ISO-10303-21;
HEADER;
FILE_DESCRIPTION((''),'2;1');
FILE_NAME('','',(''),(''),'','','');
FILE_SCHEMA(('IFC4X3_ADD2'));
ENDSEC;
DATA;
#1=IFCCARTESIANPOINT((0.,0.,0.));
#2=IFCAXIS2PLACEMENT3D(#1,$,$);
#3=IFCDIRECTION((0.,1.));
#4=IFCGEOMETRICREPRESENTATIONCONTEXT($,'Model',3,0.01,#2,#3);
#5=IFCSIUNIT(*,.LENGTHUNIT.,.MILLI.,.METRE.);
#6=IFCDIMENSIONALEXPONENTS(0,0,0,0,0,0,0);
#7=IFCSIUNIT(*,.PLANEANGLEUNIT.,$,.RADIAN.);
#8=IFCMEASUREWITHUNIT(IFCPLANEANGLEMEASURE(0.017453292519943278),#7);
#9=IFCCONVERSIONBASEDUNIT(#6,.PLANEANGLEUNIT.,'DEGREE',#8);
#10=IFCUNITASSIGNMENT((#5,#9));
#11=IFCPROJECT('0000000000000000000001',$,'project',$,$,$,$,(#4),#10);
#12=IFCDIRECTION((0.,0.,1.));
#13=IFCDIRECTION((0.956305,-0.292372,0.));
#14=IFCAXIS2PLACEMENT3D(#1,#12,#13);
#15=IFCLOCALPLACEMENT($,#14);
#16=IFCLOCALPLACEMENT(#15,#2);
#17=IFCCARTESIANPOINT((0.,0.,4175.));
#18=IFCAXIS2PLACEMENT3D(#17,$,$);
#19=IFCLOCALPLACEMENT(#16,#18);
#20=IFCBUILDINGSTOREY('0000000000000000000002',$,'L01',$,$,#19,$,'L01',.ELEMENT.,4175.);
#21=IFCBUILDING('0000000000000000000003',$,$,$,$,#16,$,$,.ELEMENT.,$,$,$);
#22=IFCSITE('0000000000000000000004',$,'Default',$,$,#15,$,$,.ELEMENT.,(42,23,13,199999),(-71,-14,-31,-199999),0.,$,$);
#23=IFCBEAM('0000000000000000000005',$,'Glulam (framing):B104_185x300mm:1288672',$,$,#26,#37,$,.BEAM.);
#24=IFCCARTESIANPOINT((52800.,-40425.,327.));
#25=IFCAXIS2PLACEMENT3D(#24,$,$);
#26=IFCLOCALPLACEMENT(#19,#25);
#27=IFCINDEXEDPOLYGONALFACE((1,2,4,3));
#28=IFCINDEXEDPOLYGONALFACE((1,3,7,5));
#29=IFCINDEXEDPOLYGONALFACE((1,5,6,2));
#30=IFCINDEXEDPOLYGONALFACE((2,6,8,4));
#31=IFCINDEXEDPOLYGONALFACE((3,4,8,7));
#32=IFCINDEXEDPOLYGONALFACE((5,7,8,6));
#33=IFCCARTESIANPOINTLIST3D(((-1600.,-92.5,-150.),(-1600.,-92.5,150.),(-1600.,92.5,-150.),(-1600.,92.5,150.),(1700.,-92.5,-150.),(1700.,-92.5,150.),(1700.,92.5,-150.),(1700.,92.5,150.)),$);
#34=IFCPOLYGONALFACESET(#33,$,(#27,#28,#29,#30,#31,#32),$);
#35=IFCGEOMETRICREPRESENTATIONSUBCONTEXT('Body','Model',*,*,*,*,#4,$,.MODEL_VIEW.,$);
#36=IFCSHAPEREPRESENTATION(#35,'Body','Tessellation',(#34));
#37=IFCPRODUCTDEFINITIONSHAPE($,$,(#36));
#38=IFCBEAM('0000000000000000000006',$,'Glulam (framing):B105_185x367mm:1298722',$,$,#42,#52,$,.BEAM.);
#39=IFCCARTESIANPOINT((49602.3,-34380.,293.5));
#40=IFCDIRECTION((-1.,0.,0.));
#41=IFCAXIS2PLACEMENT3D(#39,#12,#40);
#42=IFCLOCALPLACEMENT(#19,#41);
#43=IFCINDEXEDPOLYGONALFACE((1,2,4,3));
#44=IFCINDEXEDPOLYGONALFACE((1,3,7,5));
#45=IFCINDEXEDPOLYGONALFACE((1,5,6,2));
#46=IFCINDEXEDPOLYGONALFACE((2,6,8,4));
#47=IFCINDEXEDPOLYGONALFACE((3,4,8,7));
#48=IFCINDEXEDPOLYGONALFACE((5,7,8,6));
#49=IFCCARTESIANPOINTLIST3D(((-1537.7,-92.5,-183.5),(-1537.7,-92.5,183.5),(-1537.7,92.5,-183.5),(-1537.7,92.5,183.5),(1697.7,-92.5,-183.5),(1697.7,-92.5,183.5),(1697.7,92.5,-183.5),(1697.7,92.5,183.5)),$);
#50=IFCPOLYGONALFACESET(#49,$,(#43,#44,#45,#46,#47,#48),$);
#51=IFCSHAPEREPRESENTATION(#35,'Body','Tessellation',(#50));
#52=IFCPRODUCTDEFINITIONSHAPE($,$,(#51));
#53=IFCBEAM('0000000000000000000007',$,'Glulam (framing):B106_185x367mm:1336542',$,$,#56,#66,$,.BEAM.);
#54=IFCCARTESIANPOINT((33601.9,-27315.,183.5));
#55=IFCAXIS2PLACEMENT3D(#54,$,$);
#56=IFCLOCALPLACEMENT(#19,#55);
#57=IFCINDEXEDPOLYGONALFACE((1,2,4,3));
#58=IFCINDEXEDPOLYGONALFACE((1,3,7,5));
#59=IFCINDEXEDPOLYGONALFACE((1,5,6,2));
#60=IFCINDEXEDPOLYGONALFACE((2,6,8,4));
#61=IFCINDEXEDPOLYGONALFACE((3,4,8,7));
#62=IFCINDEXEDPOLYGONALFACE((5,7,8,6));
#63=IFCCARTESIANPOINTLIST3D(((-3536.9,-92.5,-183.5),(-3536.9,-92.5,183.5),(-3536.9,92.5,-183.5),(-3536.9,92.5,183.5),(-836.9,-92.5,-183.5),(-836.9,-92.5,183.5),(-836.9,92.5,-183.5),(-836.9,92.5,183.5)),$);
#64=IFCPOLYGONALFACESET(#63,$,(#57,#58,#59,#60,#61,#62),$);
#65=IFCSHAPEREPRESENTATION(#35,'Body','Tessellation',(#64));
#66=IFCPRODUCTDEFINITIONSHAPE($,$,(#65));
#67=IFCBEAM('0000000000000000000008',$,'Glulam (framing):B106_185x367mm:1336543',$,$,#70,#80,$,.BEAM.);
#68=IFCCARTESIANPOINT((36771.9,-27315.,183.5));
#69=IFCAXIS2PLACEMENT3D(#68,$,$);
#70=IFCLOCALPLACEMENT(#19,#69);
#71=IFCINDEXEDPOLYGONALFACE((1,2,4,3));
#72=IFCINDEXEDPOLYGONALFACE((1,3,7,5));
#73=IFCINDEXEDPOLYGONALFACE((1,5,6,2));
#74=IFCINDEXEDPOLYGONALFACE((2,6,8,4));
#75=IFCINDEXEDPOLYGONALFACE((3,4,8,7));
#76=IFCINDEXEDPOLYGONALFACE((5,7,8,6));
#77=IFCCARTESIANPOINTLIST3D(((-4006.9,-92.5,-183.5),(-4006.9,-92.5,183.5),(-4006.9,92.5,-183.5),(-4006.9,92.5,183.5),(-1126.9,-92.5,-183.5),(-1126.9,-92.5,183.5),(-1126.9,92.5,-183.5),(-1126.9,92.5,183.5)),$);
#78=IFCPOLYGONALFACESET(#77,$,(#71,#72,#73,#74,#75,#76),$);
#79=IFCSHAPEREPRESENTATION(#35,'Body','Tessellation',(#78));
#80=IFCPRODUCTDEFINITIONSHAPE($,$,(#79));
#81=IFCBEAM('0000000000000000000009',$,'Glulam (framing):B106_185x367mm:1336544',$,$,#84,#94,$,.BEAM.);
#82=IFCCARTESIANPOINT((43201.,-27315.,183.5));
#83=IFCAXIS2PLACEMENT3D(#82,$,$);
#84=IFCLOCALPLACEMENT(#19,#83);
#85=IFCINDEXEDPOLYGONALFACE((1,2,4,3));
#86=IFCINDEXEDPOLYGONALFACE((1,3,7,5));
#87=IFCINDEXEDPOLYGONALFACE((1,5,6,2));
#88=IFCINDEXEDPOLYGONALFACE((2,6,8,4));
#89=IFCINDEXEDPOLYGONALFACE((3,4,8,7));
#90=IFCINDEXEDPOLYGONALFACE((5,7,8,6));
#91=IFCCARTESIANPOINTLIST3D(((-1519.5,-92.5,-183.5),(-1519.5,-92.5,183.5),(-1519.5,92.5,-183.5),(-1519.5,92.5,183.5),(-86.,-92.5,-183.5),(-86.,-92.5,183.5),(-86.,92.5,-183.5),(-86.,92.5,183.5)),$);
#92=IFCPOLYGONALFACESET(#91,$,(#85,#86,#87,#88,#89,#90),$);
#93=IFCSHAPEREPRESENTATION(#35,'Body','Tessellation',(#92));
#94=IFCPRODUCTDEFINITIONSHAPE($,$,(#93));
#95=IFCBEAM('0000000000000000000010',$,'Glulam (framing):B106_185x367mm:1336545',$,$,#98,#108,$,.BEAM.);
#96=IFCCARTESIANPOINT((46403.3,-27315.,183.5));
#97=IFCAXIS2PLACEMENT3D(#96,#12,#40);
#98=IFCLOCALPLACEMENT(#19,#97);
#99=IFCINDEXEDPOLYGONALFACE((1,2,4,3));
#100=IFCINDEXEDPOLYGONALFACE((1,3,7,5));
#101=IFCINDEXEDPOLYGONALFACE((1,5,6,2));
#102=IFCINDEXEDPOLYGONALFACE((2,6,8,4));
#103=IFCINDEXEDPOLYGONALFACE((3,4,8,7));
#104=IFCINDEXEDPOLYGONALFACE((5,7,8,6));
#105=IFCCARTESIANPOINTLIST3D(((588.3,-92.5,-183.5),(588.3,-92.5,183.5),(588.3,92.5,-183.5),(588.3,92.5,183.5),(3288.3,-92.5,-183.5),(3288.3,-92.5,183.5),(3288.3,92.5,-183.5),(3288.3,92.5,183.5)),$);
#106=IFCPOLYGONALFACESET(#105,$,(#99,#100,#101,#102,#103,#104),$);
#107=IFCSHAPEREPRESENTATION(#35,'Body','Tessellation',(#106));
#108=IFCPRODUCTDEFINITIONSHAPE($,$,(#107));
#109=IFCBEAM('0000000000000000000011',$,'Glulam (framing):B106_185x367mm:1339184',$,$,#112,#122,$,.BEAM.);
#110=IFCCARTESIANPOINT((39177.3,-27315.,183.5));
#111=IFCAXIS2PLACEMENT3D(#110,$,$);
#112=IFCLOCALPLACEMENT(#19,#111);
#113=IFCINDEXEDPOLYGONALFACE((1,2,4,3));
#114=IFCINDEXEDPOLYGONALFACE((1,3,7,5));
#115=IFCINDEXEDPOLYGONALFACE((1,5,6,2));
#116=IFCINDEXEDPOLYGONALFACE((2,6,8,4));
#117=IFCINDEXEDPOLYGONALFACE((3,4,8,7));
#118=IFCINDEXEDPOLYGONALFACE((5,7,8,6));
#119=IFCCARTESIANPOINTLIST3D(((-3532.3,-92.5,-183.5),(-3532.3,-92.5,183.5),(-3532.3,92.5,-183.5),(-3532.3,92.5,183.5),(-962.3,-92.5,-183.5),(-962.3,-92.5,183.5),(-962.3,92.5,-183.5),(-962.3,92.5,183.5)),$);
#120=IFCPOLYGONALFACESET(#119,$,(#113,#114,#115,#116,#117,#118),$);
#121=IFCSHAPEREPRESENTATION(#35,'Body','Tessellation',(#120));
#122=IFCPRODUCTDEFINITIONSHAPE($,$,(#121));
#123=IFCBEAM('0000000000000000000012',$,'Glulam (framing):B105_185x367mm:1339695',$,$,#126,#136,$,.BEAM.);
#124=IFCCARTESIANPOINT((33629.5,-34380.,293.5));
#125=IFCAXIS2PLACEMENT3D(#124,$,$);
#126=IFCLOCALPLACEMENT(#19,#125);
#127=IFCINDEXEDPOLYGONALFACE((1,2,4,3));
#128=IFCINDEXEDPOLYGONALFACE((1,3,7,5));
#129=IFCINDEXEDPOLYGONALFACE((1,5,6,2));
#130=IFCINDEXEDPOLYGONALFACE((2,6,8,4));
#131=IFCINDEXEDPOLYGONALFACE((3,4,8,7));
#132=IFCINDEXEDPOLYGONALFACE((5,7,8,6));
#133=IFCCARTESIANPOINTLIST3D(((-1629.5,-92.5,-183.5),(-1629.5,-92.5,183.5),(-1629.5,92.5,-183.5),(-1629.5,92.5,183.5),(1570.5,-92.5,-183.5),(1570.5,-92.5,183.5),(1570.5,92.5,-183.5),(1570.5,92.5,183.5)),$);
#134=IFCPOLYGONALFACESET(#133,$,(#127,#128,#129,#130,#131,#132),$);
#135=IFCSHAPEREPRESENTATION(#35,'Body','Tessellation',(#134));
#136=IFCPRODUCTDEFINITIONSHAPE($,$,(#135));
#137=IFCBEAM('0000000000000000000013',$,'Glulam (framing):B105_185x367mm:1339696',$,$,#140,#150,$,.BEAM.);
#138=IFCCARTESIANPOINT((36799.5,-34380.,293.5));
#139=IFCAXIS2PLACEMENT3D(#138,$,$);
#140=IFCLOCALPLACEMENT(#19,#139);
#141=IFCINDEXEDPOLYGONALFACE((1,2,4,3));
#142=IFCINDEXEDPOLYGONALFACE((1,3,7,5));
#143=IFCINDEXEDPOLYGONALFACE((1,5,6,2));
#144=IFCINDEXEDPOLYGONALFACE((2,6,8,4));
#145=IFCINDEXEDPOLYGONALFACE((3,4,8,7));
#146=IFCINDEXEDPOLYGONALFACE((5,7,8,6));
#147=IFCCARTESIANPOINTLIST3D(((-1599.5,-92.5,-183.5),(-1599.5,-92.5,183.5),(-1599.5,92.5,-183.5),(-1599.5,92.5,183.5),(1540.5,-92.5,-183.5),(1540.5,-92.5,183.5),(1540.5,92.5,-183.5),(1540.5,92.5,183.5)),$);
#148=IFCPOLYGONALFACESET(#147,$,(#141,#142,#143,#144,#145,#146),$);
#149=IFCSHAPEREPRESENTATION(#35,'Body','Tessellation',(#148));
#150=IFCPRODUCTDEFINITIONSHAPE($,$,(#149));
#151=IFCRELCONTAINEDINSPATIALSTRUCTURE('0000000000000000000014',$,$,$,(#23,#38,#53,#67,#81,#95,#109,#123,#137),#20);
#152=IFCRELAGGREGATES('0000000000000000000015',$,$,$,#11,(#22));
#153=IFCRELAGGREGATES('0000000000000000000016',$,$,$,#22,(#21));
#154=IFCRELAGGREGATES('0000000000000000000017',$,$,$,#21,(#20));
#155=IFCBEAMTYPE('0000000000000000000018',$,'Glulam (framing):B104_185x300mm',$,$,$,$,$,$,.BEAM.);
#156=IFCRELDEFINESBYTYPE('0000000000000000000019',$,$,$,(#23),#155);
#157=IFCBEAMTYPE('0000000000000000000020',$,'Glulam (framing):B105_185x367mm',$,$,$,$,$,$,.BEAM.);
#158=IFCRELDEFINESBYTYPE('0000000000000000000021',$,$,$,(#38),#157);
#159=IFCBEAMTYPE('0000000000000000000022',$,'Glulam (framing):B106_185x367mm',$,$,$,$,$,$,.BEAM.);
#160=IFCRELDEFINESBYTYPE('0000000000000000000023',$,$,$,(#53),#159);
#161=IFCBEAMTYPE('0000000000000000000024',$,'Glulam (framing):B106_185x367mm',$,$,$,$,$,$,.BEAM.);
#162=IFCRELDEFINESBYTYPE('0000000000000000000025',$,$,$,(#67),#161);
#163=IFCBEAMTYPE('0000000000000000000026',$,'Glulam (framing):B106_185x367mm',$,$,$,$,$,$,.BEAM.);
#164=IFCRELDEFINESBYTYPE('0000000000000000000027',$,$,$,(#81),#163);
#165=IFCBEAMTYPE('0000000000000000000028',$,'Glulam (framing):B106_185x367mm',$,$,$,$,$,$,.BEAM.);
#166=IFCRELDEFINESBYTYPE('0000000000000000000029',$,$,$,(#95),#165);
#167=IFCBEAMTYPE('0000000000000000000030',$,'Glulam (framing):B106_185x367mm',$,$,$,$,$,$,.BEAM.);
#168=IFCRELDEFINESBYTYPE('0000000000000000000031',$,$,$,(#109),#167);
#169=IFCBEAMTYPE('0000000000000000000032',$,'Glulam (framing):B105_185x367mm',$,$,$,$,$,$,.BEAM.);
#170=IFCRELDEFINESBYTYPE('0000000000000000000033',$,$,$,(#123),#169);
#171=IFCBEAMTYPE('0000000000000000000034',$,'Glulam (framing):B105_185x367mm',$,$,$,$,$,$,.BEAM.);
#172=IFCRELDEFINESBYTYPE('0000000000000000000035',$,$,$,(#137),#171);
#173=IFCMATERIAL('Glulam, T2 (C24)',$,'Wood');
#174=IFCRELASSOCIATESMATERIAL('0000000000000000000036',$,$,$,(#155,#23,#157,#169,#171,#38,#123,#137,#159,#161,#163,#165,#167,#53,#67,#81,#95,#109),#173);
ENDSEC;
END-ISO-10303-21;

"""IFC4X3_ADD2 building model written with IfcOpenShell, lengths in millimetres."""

from ifc_helpers import new_model, entity, si_unit, converted_unit, direction, frame, frame_2d, origin, origin_2d_with_axis, place, context, subcontext, project, spatial, rectangle, extrude, source, transform, mapped, material, material_profile, profile_set, profile_usage, type_object, type_shapes, element, save


model = new_model("IFC4X3_ADD2")

# Units and contexts
model_context = context("Model", 3, precision=0.01, world=origin(), true_north=direction((0.0, 1.0)))
body_context = subcontext(model_context, "Body", "Model", "MODEL_VIEW")
ifc_project = project(units=[si_unit("LENGTHUNIT", "METRE", prefix="MILLI"), converted_unit("PLANEANGLEUNIT", "DEGREE", entity("IfcPlaneAngleMeasure", 0.017453292519943278), si_unit("PLANEANGLEUNIT", "RADIAN"), dimensions=[0, 0, 0, 0, 0, 0, 0])], contexts=[model_context])

# Site, building, storey
site_placement = place(None, frame((0.0, 0.0, 0.0), z_axis=(0.0, 0.0, 1.0), x_axis=(0.956305, -0.292372, 0.0)))
site = spatial("IfcSite", under=ifc_project, at=site_placement, Name="Default", CompositionType="ELEMENT", RefLatitude=(42, 23, 13, 199999), RefLongitude=(-71, -14, -31, -199999), RefElevation=0.0)
building_placement = place(site_placement, origin())
building = spatial("IfcBuilding", under=site, at=building_placement, CompositionType="ELEMENT")
storey_placement = place(building_placement, frame((0.0, 0.0, 4175.0)))
storey = spatial("IfcBuildingStorey", under=building, at=storey_placement, Name="L01", LongName="L01", CompositionType="ELEMENT", Elevation=4175.0)

# Beams
ifc_material_1 = material(Name="Glulam, T2 (C24)", Category="Wood")
ifc_material_profile_1 = material_profile(ifc_material_1, rectangle(XDim=3380.0, YDim=185.0, at=origin_2d_with_axis()), Name="B104_185x300mm")
ifc_profile_set_1 = profile_set([ifc_material_profile_1], Name="B104_185x300mm")
ifc_profile_usage_1 = profile_usage(ifc_profile_set_1, cardinal=8)
beam_type_1 = type_object("IfcBeamType", Name="Glulam (framing):B104_185x300mm", PredefinedType="BEAM", material=ifc_profile_set_1)
shared_shape_1 = source(origin(), body_context, "Body", "SweptSolid", [
    extrude(rectangle(XDim=3300.0, YDim=185.0, at=origin_2d_with_axis()), frame((50.0, 0.0, -150.0), z_axis=(0.0, 0.0, 1.0), x_axis=(-1.0, 0.0, 0.0)), (0.0, 0.0, 1.0), 300.0),
])
type_shapes(beam_type_1, [shared_shape_1])
beam_1_placement = place(storey_placement, frame((52800.0, -40425.0, 327.0)))
element("IfcBeam", 1, at=beam_1_placement, inside=storey, type_object=beam_type_1, material=ifc_profile_usage_1, Name="Glulam (framing):B104_185x300mm:1288672", PredefinedType="BEAM", context=body_context, shape_type="MappedRepresentation", body=[
    mapped(shared_shape_1, transform((0.0, 0.0, 0.0), scale=1.0)),
])
ifc_material_profile_2 = material_profile(ifc_material_1, rectangle(XDim=3241.9, YDim=185.0, at=origin_2d_with_axis()), Name="B105_185x367mm")
ifc_profile_set_2 = profile_set([ifc_material_profile_2], Name="B105_185x367mm")
ifc_profile_usage_2 = profile_usage(ifc_profile_set_2, cardinal=8)
beam_type_2 = type_object("IfcBeamType", Name="Glulam (framing):B105_185x367mm", PredefinedType="BEAM", material=ifc_profile_set_2)
shared_shape_2 = source(origin(), body_context, "Body", "SweptSolid", [
    extrude(rectangle(XDim=3235.4, YDim=185.0, at=origin_2d_with_axis()), frame((80.0, 0.0, -183.5), z_axis=(0.0, 0.0, 1.0), x_axis=(-1.0, 0.0, 0.0)), (0.0, 0.0, 1.0), 367.0),
])
type_shapes(beam_type_2, [shared_shape_2])
beam_2_placement = place(storey_placement, frame((49602.3, -34380.0, 293.5), z_axis=(0.0, 0.0, 1.0), x_axis=(-1.0, 0.0, 0.0)))
element("IfcBeam", 2, at=beam_2_placement, inside=storey, type_object=beam_type_2, material=ifc_profile_usage_2, Name="Glulam (framing):B105_185x367mm:1298722", PredefinedType="BEAM", context=body_context, shape_type="MappedRepresentation", body=[
    mapped(shared_shape_2, transform((0.0, 0.0, 0.0), scale=1.0)),
])
ifc_material_profile_3 = material_profile(ifc_material_1, rectangle(XDim=2161.0, YDim=185.0, at=frame_2d((0.0, 0.0), x_axis=(1.0, 0.0))), Name="B106_185x367mm")
ifc_profile_set_3 = profile_set([ifc_material_profile_3], Name="B106_185x367mm")
ifc_profile_usage_3 = profile_usage(ifc_profile_set_3, cardinal=8)
beam_type_3 = type_object("IfcBeamType", Name="Glulam (framing):B106_185x367mm", PredefinedType="BEAM", material=ifc_profile_set_3)
shared_shape_3 = source(origin(), body_context, "Body", "SweptSolid", [
    extrude(rectangle(XDim=2700.0, YDim=185.0, at=frame_2d((0.0, 0.0), x_axis=(1.0, 0.0))), frame((-2186.9, 0.0, -183.5), z_axis=(0.0, 0.0, 1.0), x_axis=(-1.0, 0.0, 0.0)), (0.0, 0.0, 1.0), 367.0),
])
type_shapes(beam_type_3, [shared_shape_3])
beam_3_placement = place(storey_placement, frame((33601.9, -27315.0, 183.5)))
element("IfcBeam", 3, at=beam_3_placement, inside=storey, type_object=beam_type_3, material=ifc_profile_usage_3, Name="Glulam (framing):B106_185x367mm:1336542", PredefinedType="BEAM", context=body_context, shape_type="MappedRepresentation", body=[
    mapped(shared_shape_3, transform((0.0, 0.0, 0.0), scale=1.0)),
])
beam_type_4 = type_object("IfcBeamType", Name="Glulam (framing):B106_185x367mm", PredefinedType="BEAM", material=ifc_profile_set_3)
shared_shape_4 = source(origin(), body_context, "Body", "SweptSolid", [
    extrude(rectangle(XDim=2880.0, YDim=185.0, at=frame_2d((0.0, 0.0), x_axis=(1.0, 0.0))), frame((-2566.9, 0.0, -183.5), z_axis=(0.0, 0.0, 1.0), x_axis=(-1.0, 0.0, 0.0)), (0.0, 0.0, 1.0), 367.0),
])
type_shapes(beam_type_4, [shared_shape_4])
beam_4_placement = place(storey_placement, frame((36771.9, -27315.0, 183.5)))
element("IfcBeam", 4, at=beam_4_placement, inside=storey, type_object=beam_type_4, material=ifc_profile_usage_3, Name="Glulam (framing):B106_185x367mm:1336543", PredefinedType="BEAM", context=body_context, shape_type="MappedRepresentation", body=[
    mapped(shared_shape_4, transform((0.0, 0.0, 0.0), scale=1.0)),
])
beam_type_5 = type_object("IfcBeamType", Name="Glulam (framing):B106_185x367mm", PredefinedType="BEAM", material=ifc_profile_set_3)
shared_shape_5 = source(origin(), body_context, "Body", "SweptSolid", [
    extrude(rectangle(XDim=1433.5, YDim=185.0, at=frame_2d((0.0, 0.0), x_axis=(1.0, 0.0))), frame((-802.7, 0.0, -183.5), z_axis=(0.0, 0.0, 1.0), x_axis=(-1.0, 0.0, 0.0)), (0.0, 0.0, 1.0), 367.0),
])
type_shapes(beam_type_5, [shared_shape_5])
beam_5_placement = place(storey_placement, frame((43201.0, -27315.0, 183.5)))
element("IfcBeam", 5, at=beam_5_placement, inside=storey, type_object=beam_type_5, material=ifc_profile_usage_3, Name="Glulam (framing):B106_185x367mm:1336544", PredefinedType="BEAM", context=body_context, shape_type="MappedRepresentation", body=[
    mapped(shared_shape_5, transform((0.0, 0.0, 0.0), scale=1.0)),
])
beam_type_6 = type_object("IfcBeamType", Name="Glulam (framing):B106_185x367mm", PredefinedType="BEAM", material=ifc_profile_set_3)
shared_shape_6 = source(origin(), body_context, "Body", "SweptSolid", [
    extrude(rectangle(XDim=2700.0, YDim=185.0, at=origin_2d_with_axis()), frame((1938.3, 0.0, -183.5), z_axis=(0.0, 0.0, 1.0), x_axis=(-1.0, 0.0, 0.0)), (0.0, 0.0, 1.0), 367.0),
])
type_shapes(beam_type_6, [shared_shape_6])
beam_6_placement = place(storey_placement, frame((46403.3, -27315.0, 183.5), z_axis=(0.0, 0.0, 1.0), x_axis=(-1.0, 0.0, 0.0)))
element("IfcBeam", 6, at=beam_6_placement, inside=storey, type_object=beam_type_6, material=ifc_profile_usage_3, Name="Glulam (framing):B106_185x367mm:1336545", PredefinedType="BEAM", context=body_context, shape_type="MappedRepresentation", body=[
    mapped(shared_shape_6, transform((0.0, 0.0, 0.0), scale=1.0)),
])
beam_type_7 = type_object("IfcBeamType", Name="Glulam (framing):B106_185x367mm", PredefinedType="BEAM", material=ifc_profile_set_3)
shared_shape_7 = source(origin(), body_context, "Body", "SweptSolid", [
    extrude(rectangle(XDim=2570.0, YDim=185.0, at=frame_2d((0.0, 0.0), x_axis=(1.0, 0.0))), frame((-2247.3, 0.0, -183.5), z_axis=(0.0, 0.0, 1.0), x_axis=(-1.0, 0.0, 0.0)), (0.0, 0.0, 1.0), 367.0),
])
type_shapes(beam_type_7, [shared_shape_7])
beam_7_placement = place(storey_placement, frame((39177.3, -27315.0, 183.5)))
element("IfcBeam", 7, at=beam_7_placement, inside=storey, type_object=beam_type_7, material=ifc_profile_usage_3, Name="Glulam (framing):B106_185x367mm:1339184", PredefinedType="BEAM", context=body_context, shape_type="MappedRepresentation", body=[
    mapped(shared_shape_7, transform((0.0, 0.0, 0.0), scale=1.0)),
])
beam_type_8 = type_object("IfcBeamType", Name="Glulam (framing):B105_185x367mm", PredefinedType="BEAM", material=ifc_profile_set_2)
shared_shape_8 = source(origin(), body_context, "Body", "SweptSolid", [
    extrude(rectangle(XDim=3200.0, YDim=185.0, at=origin_2d_with_axis()), frame((-29.5, 0.0, -183.5), z_axis=(0.0, 0.0, 1.0), x_axis=(-1.0, 0.0, 0.0)), (0.0, 0.0, 1.0), 367.0),
])
type_shapes(beam_type_8, [shared_shape_8])
beam_8_placement = place(storey_placement, frame((33629.5, -34380.0, 293.5)))
element("IfcBeam", 8, at=beam_8_placement, inside=storey, type_object=beam_type_8, material=ifc_profile_usage_2, Name="Glulam (framing):B105_185x367mm:1339695", PredefinedType="BEAM", context=body_context, shape_type="MappedRepresentation", body=[
    mapped(shared_shape_8, transform((0.0, 0.0, 0.0), scale=1.0)),
])
beam_type_9 = type_object("IfcBeamType", Name="Glulam (framing):B105_185x367mm", PredefinedType="BEAM", material=ifc_profile_set_2)
shared_shape_9 = source(origin(), body_context, "Body", "SweptSolid", [
    extrude(rectangle(XDim=3140.0, YDim=185.0, at=origin_2d_with_axis()), frame((-29.5, 0.0, -183.5), z_axis=(0.0, 0.0, 1.0), x_axis=(-1.0, 0.0, 0.0)), (0.0, 0.0, 1.0), 367.0),
])
type_shapes(beam_type_9, [shared_shape_9])
beam_9_placement = place(storey_placement, frame((36799.5, -34380.0, 293.5)))
element("IfcBeam", 9, at=beam_9_placement, inside=storey, type_object=beam_type_9, material=ifc_profile_usage_2, Name="Glulam (framing):B105_185x367mm:1339696", PredefinedType="BEAM", context=body_context, shape_type="MappedRepresentation", body=[
    mapped(shared_shape_9, transform((0.0, 0.0, 0.0), scale=1.0)),
])

save(model, "model.ifc")
